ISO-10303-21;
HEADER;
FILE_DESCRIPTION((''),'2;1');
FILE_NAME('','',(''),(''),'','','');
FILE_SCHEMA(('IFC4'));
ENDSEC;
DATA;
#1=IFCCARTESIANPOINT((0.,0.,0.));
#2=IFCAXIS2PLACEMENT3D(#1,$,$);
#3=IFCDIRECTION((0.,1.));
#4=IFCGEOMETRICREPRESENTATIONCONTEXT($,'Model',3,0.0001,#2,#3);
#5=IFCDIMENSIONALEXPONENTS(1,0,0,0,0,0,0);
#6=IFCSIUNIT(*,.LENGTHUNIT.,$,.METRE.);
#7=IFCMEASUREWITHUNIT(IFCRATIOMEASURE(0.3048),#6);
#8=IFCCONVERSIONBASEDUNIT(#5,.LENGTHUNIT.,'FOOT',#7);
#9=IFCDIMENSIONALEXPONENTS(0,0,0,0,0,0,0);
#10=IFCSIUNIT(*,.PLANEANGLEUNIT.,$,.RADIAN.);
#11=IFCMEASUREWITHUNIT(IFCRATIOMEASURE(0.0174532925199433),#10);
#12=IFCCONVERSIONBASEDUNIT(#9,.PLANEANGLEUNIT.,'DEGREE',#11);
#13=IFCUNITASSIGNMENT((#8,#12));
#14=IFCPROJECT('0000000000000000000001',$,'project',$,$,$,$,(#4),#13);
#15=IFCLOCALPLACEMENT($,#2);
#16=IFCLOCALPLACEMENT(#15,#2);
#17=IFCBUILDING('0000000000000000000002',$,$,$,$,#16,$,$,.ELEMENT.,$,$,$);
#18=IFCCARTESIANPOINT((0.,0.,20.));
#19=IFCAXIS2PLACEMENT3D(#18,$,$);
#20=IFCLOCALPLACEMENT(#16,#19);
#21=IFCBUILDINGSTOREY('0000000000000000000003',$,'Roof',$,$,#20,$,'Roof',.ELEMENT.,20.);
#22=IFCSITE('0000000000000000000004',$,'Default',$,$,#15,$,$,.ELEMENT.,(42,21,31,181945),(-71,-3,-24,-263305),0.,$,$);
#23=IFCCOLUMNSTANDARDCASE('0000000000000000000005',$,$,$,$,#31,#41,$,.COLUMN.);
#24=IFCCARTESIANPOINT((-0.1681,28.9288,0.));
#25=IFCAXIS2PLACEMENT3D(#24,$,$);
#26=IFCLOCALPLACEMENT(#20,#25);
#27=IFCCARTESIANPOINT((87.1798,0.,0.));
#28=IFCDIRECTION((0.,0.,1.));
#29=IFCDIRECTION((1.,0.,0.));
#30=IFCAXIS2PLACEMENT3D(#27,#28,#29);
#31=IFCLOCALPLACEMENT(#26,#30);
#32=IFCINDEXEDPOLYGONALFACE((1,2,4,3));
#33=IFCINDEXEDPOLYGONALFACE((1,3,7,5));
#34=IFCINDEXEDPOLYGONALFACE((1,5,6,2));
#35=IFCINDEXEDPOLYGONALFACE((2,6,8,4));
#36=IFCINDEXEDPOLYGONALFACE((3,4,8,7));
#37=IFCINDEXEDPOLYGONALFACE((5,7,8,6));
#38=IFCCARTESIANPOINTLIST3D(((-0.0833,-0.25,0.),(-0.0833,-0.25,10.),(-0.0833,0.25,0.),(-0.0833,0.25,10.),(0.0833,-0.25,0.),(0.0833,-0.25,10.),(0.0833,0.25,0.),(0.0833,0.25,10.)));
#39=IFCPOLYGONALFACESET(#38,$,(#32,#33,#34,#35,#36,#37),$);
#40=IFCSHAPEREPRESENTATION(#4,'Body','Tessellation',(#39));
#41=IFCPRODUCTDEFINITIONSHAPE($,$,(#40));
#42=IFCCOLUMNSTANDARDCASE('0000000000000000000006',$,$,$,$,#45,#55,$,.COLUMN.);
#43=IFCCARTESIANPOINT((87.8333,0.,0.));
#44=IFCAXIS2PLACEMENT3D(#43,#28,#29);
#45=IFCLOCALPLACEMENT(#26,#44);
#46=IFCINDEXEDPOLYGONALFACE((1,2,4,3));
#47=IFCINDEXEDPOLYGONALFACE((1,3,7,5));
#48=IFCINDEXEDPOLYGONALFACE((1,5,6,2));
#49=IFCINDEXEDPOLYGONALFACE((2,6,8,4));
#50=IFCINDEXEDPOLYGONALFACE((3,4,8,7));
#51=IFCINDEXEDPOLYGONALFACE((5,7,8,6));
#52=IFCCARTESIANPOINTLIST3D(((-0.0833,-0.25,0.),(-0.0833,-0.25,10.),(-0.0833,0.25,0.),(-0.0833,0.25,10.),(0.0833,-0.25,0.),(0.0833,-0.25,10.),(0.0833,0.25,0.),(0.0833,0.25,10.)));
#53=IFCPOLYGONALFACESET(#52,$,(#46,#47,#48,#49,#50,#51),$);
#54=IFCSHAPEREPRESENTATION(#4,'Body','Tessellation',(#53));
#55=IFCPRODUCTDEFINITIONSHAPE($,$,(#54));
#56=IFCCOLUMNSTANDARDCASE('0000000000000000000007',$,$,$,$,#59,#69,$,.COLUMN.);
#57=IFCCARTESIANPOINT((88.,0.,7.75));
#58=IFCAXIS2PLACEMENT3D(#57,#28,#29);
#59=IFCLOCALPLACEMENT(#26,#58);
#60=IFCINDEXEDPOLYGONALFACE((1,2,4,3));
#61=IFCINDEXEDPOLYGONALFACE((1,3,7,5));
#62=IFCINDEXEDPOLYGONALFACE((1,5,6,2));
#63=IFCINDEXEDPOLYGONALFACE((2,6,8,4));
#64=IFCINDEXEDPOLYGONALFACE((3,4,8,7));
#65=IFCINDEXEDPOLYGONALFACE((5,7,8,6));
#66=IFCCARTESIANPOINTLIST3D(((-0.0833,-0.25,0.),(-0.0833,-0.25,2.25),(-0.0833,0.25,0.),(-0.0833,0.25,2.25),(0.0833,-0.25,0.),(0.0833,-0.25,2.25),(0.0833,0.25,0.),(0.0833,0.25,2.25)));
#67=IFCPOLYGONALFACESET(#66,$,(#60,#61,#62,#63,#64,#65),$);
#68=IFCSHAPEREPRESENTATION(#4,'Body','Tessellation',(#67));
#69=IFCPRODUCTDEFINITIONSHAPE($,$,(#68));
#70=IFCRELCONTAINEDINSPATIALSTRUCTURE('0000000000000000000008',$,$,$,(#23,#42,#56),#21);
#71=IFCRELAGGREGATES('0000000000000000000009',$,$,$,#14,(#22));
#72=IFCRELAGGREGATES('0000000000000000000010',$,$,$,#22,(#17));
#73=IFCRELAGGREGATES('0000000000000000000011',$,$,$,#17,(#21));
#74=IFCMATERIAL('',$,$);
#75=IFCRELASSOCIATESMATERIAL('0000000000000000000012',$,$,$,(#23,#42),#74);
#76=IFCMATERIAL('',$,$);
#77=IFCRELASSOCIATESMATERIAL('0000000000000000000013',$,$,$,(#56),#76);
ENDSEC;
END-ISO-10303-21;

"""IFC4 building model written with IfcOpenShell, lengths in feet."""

from ifc_helpers import new_model, entity, si_unit, converted_unit, direction, frame, origin, place, context, project, spatial, rectangle, extrude, material, element, save


model = new_model("IFC4")

# Units and contexts
model_context = context("Model", 3, precision=0.0001, world=origin(), true_north=direction((0.0, 1.0)))
ifc_project = project(units=[converted_unit("LENGTHUNIT", "FOOT", entity("IfcRatioMeasure", 0.3048), si_unit("LENGTHUNIT", "METRE"), dimensions=[1, 0, 0, 0, 0, 0, 0]), converted_unit("PLANEANGLEUNIT", "DEGREE", entity("IfcRatioMeasure", 0.0174532925199433), si_unit("PLANEANGLEUNIT", "RADIAN"), dimensions=[0, 0, 0, 0, 0, 0, 0])], contexts=[model_context])

# Site, building, storey
site_placement = place(None, origin())
site = spatial("IfcSite", under=ifc_project, at=site_placement, Name="Default", CompositionType="ELEMENT", RefLatitude=(42, 21, 31, 181945), RefLongitude=(-71, -3, -24, -263305), RefElevation=0.0)
building_placement = place(site_placement, origin())
building = spatial("IfcBuilding", under=site, at=building_placement, CompositionType="ELEMENT")
storey_placement = place(building_placement, frame((0.0, 0.0, 20.0)))
storey = spatial("IfcBuildingStorey", under=building, at=storey_placement, Name="Roof", LongName="Roof", CompositionType="ELEMENT", Elevation=20.0)

# Columns
ifc_material_1 = material(Name="")
placement = place(storey_placement, frame((-0.1681, 28.9288, 0.0)))
for number, where, z_axis, x_axis in (
    (1, (87.1798, 0.0, 0.0), (0.0, 0.0, 1.0), (1.0, 0.0, 0.0)),
    (2, (87.8333, 0.0, 0.0), (0.0, 0.0, 1.0), (1.0, 0.0, 0.0)),
):
    element("IfcColumnStandardCase", number, at=place(placement, frame(where, z_axis=z_axis, x_axis=x_axis)), inside=storey, material=ifc_material_1, PredefinedType="COLUMN", context=model_context, shape_type="SweptSolid", body=[
        extrude(rectangle(XDim=0.1667, YDim=0.5), origin(), (0.0, 0.0, 1.0), 10.0),
    ])
ifc_material_2 = material(Name="")
for number, where, z_axis, x_axis in (
    (3, (88.0, 0.0, 7.75), (0.0, 0.0, 1.0), (1.0, 0.0, 0.0)),
):
    element("IfcColumnStandardCase", number, at=place(placement, frame(where, z_axis=z_axis, x_axis=x_axis)), inside=storey, material=ifc_material_2, PredefinedType="COLUMN", context=model_context, shape_type="SweptSolid", body=[
        extrude(rectangle(XDim=0.1667, YDim=0.5), origin(), (0.0, 0.0, 1.0), 2.25),
    ])

save(model, "model.ifc")
